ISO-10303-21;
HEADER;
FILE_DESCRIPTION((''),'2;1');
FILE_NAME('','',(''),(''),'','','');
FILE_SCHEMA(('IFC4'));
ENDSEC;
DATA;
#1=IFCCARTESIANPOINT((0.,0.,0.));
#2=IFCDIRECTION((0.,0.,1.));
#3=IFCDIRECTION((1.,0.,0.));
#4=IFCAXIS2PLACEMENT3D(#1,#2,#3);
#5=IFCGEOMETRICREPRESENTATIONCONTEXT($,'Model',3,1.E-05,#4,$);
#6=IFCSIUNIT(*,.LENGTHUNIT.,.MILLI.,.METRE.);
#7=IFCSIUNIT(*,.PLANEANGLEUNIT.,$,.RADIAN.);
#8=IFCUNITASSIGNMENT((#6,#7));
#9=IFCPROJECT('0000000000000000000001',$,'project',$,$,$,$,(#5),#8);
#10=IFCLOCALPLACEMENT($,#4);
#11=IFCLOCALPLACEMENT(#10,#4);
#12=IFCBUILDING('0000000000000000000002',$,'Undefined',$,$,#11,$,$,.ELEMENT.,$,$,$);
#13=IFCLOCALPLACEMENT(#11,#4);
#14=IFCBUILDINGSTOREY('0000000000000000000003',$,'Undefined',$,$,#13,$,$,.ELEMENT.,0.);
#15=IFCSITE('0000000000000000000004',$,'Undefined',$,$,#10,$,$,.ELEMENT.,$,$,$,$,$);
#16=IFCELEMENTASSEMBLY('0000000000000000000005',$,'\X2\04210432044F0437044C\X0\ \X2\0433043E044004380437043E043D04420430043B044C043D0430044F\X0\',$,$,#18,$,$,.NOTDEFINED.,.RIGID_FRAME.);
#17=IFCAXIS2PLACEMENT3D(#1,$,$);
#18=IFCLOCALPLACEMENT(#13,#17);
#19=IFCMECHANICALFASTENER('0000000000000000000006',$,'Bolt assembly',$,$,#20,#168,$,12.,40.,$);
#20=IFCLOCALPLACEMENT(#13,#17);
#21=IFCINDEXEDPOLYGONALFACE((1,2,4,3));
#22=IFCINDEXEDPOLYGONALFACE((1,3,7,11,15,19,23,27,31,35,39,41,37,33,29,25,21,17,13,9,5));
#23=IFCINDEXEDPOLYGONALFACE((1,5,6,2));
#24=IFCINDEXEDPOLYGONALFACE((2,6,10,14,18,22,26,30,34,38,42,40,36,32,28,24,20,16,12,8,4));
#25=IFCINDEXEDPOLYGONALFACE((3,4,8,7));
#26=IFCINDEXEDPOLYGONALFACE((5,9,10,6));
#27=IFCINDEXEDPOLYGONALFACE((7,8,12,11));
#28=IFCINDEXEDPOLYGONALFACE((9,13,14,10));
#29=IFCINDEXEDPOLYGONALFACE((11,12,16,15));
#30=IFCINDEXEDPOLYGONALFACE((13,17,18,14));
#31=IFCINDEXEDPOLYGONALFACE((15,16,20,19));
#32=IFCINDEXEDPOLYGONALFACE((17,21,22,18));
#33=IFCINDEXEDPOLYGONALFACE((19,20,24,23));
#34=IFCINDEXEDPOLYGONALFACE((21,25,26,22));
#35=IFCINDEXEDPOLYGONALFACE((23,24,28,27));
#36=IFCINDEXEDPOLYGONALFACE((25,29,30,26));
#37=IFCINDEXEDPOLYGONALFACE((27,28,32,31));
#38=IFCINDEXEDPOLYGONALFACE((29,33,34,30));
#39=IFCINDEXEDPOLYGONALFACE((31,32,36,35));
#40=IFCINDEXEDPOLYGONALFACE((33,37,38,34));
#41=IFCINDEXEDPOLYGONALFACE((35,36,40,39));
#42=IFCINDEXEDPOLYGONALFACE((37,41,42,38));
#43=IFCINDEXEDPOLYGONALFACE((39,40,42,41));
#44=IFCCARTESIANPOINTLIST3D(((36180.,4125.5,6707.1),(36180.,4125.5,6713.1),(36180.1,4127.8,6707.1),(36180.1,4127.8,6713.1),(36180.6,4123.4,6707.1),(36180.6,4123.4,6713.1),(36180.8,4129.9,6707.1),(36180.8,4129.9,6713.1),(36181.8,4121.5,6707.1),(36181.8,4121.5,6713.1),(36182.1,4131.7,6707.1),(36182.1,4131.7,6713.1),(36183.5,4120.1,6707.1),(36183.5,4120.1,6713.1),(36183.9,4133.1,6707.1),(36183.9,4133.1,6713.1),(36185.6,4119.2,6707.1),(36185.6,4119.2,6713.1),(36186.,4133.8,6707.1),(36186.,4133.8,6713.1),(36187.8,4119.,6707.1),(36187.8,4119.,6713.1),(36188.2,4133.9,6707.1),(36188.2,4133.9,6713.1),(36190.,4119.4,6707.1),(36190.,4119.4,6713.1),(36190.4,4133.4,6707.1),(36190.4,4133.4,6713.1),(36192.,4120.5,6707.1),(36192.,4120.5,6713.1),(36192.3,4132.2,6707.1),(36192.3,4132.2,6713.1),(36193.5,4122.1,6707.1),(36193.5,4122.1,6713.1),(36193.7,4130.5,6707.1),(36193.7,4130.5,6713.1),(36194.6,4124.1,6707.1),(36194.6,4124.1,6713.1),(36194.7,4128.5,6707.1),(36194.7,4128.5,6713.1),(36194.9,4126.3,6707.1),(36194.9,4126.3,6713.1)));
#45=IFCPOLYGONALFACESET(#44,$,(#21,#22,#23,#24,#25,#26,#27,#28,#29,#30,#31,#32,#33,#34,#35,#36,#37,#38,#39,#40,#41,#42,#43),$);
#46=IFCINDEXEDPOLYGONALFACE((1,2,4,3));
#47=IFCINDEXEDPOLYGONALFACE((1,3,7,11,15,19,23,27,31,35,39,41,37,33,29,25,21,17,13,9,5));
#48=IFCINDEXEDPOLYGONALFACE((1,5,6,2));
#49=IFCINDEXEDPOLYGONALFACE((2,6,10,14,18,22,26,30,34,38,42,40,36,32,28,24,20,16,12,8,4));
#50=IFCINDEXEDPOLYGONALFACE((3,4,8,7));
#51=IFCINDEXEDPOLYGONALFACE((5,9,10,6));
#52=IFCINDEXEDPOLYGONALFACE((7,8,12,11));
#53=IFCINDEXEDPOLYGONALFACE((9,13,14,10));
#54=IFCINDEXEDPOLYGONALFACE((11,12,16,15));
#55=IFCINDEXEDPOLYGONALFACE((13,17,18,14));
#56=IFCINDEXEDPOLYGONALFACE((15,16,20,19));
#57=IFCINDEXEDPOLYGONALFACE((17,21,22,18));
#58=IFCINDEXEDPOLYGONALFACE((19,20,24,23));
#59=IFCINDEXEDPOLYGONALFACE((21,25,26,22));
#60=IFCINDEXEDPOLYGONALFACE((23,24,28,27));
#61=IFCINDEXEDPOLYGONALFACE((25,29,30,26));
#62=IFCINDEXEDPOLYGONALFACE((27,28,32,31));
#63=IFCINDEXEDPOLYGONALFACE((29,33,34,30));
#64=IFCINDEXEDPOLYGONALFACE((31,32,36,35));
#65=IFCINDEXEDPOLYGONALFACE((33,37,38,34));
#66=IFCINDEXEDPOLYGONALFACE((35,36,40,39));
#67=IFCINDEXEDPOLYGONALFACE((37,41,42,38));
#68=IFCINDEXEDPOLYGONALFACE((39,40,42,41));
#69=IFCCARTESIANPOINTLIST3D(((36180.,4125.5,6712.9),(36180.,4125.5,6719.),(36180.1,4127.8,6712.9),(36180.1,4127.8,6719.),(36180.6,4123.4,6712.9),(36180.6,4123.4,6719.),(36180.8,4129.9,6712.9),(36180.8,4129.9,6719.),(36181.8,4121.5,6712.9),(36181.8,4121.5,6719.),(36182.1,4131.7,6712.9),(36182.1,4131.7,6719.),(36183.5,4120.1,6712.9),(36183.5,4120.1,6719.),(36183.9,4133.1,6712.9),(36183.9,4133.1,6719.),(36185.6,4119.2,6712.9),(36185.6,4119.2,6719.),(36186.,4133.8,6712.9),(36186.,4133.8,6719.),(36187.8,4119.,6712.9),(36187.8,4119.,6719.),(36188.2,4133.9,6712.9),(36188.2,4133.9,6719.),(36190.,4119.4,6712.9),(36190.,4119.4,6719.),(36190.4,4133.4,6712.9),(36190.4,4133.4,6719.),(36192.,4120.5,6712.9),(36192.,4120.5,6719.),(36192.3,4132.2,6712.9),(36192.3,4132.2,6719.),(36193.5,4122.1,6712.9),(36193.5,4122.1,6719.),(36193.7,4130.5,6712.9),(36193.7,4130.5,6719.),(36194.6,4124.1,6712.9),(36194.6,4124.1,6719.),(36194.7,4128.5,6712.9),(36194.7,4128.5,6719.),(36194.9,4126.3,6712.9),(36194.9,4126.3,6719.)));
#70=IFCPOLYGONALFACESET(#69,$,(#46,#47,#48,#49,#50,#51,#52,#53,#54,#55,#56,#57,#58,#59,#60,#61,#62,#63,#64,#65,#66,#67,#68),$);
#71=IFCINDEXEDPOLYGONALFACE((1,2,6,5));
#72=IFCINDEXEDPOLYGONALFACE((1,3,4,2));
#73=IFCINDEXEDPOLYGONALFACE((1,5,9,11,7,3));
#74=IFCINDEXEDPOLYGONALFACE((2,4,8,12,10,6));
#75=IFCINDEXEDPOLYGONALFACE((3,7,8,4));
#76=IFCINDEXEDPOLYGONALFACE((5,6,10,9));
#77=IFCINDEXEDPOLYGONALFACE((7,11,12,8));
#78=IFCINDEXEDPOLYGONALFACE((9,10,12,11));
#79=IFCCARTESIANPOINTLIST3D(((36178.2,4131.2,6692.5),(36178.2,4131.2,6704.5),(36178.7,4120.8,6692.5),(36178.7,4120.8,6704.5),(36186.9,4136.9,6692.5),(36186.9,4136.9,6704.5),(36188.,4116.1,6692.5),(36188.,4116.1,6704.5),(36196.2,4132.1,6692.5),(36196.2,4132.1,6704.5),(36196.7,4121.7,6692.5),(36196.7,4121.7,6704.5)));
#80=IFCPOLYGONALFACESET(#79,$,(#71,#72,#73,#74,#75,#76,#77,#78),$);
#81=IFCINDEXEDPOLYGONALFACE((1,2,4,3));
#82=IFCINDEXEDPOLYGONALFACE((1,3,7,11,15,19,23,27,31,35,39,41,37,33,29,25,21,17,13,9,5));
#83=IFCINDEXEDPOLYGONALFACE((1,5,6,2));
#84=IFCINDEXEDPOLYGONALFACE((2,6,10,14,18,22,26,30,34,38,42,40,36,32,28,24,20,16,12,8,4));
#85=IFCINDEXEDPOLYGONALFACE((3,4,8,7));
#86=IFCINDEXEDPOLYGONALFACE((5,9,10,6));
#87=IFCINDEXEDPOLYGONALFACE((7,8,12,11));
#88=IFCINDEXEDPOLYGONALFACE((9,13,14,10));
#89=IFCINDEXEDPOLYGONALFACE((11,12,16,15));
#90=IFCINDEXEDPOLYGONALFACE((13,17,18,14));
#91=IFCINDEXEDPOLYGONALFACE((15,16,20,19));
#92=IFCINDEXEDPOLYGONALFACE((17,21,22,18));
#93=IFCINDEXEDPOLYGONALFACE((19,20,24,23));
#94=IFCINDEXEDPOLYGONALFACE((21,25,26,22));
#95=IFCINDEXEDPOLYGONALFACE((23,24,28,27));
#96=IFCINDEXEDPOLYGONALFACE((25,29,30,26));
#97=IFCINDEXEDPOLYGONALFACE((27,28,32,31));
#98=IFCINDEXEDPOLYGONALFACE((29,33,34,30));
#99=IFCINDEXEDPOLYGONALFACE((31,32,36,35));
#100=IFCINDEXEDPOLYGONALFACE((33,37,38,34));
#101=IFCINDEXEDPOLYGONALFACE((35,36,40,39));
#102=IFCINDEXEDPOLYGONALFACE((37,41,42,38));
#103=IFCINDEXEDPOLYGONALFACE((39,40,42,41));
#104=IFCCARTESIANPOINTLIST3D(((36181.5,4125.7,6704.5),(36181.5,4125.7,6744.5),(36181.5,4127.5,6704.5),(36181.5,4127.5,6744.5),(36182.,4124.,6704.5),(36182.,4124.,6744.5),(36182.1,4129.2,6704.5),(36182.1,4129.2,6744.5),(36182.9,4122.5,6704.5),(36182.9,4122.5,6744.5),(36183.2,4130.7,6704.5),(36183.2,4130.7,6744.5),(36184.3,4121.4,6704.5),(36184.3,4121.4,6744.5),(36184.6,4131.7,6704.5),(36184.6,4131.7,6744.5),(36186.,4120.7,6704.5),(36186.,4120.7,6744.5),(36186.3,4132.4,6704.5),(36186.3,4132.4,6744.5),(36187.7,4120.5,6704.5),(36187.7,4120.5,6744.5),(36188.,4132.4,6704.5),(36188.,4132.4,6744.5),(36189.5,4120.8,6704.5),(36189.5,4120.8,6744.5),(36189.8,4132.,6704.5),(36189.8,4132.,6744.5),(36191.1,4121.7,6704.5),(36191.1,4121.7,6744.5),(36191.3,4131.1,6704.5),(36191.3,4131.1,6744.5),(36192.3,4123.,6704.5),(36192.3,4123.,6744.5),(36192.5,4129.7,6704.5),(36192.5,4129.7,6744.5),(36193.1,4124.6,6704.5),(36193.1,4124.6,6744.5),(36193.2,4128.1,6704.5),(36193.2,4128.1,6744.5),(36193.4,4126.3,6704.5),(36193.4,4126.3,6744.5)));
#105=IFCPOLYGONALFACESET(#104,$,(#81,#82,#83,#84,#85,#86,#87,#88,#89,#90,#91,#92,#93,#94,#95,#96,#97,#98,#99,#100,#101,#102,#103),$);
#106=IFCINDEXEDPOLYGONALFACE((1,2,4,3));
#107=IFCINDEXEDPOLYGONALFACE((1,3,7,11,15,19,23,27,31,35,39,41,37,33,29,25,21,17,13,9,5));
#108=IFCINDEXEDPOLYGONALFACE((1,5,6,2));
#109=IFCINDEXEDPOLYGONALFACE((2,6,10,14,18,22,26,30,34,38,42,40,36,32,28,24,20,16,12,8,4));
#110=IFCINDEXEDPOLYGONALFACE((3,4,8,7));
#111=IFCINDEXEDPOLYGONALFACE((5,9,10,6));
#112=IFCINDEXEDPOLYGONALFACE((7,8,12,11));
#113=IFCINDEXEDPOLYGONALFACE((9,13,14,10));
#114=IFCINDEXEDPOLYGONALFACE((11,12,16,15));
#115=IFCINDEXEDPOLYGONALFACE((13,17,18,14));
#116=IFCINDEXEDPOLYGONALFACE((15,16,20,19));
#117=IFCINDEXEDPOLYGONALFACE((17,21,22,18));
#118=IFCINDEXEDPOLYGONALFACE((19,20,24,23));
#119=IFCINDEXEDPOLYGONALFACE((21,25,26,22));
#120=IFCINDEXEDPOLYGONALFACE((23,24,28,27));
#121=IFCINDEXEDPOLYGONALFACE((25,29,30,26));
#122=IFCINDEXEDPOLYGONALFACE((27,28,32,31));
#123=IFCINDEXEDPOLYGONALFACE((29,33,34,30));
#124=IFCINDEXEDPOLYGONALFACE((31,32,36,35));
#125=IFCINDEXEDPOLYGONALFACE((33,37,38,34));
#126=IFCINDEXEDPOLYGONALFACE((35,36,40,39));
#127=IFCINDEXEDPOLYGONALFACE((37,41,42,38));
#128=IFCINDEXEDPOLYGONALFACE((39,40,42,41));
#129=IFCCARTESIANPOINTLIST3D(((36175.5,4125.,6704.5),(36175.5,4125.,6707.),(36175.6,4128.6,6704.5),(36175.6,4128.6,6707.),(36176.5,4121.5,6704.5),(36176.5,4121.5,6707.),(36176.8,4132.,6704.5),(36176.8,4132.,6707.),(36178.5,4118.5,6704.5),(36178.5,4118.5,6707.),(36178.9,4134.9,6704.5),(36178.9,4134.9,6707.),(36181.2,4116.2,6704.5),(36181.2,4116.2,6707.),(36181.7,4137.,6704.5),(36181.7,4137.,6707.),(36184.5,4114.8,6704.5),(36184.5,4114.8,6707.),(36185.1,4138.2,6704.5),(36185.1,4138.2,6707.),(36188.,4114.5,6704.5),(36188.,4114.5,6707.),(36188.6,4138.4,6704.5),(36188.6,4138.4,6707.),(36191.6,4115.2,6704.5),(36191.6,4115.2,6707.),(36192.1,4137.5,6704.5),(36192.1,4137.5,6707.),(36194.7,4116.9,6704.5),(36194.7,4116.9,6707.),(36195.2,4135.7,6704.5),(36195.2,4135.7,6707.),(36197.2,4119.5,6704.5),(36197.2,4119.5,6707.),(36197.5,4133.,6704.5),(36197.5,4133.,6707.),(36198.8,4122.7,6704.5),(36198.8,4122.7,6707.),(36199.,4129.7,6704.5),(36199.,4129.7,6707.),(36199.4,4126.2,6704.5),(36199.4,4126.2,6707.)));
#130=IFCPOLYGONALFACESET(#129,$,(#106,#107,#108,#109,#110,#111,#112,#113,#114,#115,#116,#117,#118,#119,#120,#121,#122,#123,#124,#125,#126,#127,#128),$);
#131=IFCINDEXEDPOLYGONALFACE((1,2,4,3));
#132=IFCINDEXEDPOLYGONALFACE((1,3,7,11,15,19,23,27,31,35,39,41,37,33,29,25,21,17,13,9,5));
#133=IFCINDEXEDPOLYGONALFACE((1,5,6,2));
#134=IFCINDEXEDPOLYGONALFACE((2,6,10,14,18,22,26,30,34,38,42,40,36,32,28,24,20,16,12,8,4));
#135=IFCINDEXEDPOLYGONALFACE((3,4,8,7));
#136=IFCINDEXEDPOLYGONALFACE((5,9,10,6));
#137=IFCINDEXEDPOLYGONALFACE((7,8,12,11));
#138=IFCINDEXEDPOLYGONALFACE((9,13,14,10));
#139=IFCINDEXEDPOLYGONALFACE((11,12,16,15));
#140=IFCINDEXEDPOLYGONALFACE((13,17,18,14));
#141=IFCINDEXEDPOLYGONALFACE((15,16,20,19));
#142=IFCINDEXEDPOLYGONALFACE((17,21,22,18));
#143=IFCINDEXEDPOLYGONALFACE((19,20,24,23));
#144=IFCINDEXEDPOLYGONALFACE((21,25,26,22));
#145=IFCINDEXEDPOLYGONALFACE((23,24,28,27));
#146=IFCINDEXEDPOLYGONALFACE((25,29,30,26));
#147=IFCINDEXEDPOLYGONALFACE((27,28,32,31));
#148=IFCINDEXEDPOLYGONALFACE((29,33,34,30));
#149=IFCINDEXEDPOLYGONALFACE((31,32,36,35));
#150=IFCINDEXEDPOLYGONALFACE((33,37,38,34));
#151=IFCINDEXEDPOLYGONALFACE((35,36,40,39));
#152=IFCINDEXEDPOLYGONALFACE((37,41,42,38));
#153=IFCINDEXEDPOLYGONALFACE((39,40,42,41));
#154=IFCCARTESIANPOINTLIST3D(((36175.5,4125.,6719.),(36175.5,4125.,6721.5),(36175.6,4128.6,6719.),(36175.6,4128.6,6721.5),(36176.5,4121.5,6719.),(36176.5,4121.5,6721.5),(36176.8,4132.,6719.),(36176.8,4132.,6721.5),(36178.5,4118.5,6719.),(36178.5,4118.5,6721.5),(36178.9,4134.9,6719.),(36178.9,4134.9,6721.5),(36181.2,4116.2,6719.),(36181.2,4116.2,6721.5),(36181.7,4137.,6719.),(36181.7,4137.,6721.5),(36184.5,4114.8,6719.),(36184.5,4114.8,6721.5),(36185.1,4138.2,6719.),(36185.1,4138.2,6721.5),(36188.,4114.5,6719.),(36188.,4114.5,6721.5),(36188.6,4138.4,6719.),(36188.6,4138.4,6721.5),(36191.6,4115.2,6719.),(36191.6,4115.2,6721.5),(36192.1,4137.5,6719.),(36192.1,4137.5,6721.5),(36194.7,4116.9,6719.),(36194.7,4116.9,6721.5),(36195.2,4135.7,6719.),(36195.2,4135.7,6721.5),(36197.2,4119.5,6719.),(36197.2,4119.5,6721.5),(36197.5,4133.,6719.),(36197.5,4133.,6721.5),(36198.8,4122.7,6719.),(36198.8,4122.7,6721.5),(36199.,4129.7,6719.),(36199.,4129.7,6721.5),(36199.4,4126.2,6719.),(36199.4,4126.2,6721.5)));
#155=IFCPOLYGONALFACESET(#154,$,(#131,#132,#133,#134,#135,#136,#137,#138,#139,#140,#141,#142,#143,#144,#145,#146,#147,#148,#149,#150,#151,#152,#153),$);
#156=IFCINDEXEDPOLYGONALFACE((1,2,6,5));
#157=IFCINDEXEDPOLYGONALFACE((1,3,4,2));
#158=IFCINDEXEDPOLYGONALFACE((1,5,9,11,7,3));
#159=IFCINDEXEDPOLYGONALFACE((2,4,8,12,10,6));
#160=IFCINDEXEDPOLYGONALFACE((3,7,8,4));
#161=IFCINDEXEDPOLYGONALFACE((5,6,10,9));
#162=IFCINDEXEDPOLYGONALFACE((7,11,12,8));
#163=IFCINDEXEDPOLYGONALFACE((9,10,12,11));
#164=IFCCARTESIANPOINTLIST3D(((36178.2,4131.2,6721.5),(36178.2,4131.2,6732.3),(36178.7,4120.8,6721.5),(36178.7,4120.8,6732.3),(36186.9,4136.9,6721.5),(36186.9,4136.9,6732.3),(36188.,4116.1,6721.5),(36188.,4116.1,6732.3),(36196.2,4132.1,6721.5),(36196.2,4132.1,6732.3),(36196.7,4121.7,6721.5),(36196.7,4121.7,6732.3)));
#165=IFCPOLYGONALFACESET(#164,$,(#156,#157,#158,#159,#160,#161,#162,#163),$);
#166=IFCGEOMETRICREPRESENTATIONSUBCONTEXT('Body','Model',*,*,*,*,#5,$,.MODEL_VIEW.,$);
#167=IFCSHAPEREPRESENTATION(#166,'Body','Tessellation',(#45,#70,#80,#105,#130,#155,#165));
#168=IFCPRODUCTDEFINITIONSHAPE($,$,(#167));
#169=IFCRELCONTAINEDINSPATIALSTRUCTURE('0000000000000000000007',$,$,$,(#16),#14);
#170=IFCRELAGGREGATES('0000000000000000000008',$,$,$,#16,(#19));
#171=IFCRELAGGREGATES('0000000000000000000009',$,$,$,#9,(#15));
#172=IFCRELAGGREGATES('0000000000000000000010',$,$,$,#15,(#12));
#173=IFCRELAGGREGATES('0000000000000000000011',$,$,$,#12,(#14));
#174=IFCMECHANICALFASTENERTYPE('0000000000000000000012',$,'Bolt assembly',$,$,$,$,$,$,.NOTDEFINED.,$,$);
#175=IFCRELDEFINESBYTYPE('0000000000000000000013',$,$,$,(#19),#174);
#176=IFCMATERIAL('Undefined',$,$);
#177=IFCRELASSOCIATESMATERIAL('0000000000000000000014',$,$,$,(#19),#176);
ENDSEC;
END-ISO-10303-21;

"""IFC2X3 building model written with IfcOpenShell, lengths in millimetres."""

from ifc_helpers import new_model, si_unit, frame, origin_with_axes, origin_2d_with_axis, place, context, subcontext, project, spatial, polyline, circle, outline, extrude, source, transform, mapped, material, type_object, element, aggregate, save


model = new_model("IFC2X3")

# Units and contexts
model_context = context("Model", 3, precision=1e-05, world=origin_with_axes())
body_context = subcontext(model_context, "Body", "Model", "MODEL_VIEW")
ifc_project = project(units=[si_unit("LENGTHUNIT", "METRE", prefix="MILLI"), si_unit("PLANEANGLEUNIT", "RADIAN")], contexts=[model_context])

# Site, building, storey
site_placement = place(None, origin_with_axes())
site = spatial("IfcSite", under=ifc_project, at=site_placement, Name="Undefined", CompositionType="ELEMENT")
building_placement = place(site_placement, origin_with_axes())
building = spatial("IfcBuilding", under=site, at=building_placement, Name="Undefined", CompositionType="ELEMENT")
storey_placement = place(building_placement, origin_with_axes())
storey = spatial("IfcBuildingStorey", under=building, at=storey_placement, Name="Undefined", CompositionType="ELEMENT", Elevation=0.0)

# Element assembly
assembly_1_placement = place(storey_placement, origin_with_axes())
assembly_1 = element("IfcElementAssembly", 1, at=assembly_1_placement, inside=storey, Name="Связь горизонтальная", AssemblyPlace="NOTDEFINED", PredefinedType="RIGID_FRAME")

# Mechanical fastener
ifc_material_1 = material(Name="Undefined")
mechanical_fastener_type = type_object("IfcMechanicalFastenerType", Name="Bolt assembly")
shared_shape_1 = source(origin_with_axes(), body_context, "Body", "SweptSolid", [
    extrude(circle(Radius=7.5, at=origin_2d_with_axis()), frame((0.0, 0.1, 0.0), z_axis=(0.0, 1.0, 0.0), x_axis=(1.0, 0.0, 0.0)), (0.0, 0.0, 1.0), 6.0),
    extrude(circle(Radius=7.5, at=origin_2d_with_axis()), frame((0.0, 5.9, 0.0), z_axis=(0.0, 1.0, 0.0), x_axis=(1.0, 0.0, 0.0)), (0.0, 0.0, 1.0), 6.1),
    extrude(outline(polyline([(10.4, 0.0), (5.2, 9.0), (-5.2, 9.0), (-10.4, 0.0), (-5.2, -9.0), (5.2, -9.0), (10.4, 0.0)])), frame((0.0, -14.5, 0.0), z_axis=(0.0, 1.0, 0.0), x_axis=(1.0, 0.0, 0.0)), (0.0, 0.0, 1.0), 12.0),
    extrude(circle(Radius=6.0, at=origin_2d_with_axis()), frame((0.0, -2.5, 0.0), z_axis=(0.0, 1.0, 0.0), x_axis=(1.0, 0.0, 0.0)), (0.0, 0.0, 1.0), 40.0),
    extrude(circle(Radius=12.0, at=origin_2d_with_axis()), frame((0.0, -2.5, 0.0), z_axis=(0.0, 1.0, 0.0), x_axis=(1.0, 0.0, 0.0)), (0.0, 0.0, 1.0), 2.5),
    extrude(circle(Radius=12.0, at=origin_2d_with_axis()), frame((0.0, 12.0, 0.0), z_axis=(0.0, 1.0, 0.0), x_axis=(1.0, 0.0, 0.0)), (0.0, 0.0, 1.0), 2.5),
    extrude(outline(polyline([(10.4, 0.0), (5.2, 9.0), (-5.2, 9.0), (-10.4, 0.0), (-5.2, -9.0), (5.2, -9.0), (10.4, 0.0)])), frame((0.0, 14.5, 0.0), z_axis=(0.0, 1.0, 0.0), x_axis=(1.0, 0.0, 0.0)), (0.0, 0.0, 1.0), 10.8),
])
mechanical_fastener_1_placement = place(assembly_1_placement, frame((36187.4, 4126.5, 6707.0), z_axis=(0.542525, -0.840039, 0.0), x_axis=(0.840039, 0.542525, 0.0)))
mechanical_fastener_1 = element("IfcMechanicalFastener", 2, at=mechanical_fastener_1_placement, type_object=mechanical_fastener_type, material=ifc_material_1, Name="Bolt assembly", NominalDiameter=12.0, NominalLength=40.0, context=body_context, shape_type="MappedRepresentation", body=[
    mapped(shared_shape_1, transform((0.0, 0.0, 0.0))),
])
aggregate(assembly_1, [mechanical_fastener_1])

save(model, "model.ifc")
